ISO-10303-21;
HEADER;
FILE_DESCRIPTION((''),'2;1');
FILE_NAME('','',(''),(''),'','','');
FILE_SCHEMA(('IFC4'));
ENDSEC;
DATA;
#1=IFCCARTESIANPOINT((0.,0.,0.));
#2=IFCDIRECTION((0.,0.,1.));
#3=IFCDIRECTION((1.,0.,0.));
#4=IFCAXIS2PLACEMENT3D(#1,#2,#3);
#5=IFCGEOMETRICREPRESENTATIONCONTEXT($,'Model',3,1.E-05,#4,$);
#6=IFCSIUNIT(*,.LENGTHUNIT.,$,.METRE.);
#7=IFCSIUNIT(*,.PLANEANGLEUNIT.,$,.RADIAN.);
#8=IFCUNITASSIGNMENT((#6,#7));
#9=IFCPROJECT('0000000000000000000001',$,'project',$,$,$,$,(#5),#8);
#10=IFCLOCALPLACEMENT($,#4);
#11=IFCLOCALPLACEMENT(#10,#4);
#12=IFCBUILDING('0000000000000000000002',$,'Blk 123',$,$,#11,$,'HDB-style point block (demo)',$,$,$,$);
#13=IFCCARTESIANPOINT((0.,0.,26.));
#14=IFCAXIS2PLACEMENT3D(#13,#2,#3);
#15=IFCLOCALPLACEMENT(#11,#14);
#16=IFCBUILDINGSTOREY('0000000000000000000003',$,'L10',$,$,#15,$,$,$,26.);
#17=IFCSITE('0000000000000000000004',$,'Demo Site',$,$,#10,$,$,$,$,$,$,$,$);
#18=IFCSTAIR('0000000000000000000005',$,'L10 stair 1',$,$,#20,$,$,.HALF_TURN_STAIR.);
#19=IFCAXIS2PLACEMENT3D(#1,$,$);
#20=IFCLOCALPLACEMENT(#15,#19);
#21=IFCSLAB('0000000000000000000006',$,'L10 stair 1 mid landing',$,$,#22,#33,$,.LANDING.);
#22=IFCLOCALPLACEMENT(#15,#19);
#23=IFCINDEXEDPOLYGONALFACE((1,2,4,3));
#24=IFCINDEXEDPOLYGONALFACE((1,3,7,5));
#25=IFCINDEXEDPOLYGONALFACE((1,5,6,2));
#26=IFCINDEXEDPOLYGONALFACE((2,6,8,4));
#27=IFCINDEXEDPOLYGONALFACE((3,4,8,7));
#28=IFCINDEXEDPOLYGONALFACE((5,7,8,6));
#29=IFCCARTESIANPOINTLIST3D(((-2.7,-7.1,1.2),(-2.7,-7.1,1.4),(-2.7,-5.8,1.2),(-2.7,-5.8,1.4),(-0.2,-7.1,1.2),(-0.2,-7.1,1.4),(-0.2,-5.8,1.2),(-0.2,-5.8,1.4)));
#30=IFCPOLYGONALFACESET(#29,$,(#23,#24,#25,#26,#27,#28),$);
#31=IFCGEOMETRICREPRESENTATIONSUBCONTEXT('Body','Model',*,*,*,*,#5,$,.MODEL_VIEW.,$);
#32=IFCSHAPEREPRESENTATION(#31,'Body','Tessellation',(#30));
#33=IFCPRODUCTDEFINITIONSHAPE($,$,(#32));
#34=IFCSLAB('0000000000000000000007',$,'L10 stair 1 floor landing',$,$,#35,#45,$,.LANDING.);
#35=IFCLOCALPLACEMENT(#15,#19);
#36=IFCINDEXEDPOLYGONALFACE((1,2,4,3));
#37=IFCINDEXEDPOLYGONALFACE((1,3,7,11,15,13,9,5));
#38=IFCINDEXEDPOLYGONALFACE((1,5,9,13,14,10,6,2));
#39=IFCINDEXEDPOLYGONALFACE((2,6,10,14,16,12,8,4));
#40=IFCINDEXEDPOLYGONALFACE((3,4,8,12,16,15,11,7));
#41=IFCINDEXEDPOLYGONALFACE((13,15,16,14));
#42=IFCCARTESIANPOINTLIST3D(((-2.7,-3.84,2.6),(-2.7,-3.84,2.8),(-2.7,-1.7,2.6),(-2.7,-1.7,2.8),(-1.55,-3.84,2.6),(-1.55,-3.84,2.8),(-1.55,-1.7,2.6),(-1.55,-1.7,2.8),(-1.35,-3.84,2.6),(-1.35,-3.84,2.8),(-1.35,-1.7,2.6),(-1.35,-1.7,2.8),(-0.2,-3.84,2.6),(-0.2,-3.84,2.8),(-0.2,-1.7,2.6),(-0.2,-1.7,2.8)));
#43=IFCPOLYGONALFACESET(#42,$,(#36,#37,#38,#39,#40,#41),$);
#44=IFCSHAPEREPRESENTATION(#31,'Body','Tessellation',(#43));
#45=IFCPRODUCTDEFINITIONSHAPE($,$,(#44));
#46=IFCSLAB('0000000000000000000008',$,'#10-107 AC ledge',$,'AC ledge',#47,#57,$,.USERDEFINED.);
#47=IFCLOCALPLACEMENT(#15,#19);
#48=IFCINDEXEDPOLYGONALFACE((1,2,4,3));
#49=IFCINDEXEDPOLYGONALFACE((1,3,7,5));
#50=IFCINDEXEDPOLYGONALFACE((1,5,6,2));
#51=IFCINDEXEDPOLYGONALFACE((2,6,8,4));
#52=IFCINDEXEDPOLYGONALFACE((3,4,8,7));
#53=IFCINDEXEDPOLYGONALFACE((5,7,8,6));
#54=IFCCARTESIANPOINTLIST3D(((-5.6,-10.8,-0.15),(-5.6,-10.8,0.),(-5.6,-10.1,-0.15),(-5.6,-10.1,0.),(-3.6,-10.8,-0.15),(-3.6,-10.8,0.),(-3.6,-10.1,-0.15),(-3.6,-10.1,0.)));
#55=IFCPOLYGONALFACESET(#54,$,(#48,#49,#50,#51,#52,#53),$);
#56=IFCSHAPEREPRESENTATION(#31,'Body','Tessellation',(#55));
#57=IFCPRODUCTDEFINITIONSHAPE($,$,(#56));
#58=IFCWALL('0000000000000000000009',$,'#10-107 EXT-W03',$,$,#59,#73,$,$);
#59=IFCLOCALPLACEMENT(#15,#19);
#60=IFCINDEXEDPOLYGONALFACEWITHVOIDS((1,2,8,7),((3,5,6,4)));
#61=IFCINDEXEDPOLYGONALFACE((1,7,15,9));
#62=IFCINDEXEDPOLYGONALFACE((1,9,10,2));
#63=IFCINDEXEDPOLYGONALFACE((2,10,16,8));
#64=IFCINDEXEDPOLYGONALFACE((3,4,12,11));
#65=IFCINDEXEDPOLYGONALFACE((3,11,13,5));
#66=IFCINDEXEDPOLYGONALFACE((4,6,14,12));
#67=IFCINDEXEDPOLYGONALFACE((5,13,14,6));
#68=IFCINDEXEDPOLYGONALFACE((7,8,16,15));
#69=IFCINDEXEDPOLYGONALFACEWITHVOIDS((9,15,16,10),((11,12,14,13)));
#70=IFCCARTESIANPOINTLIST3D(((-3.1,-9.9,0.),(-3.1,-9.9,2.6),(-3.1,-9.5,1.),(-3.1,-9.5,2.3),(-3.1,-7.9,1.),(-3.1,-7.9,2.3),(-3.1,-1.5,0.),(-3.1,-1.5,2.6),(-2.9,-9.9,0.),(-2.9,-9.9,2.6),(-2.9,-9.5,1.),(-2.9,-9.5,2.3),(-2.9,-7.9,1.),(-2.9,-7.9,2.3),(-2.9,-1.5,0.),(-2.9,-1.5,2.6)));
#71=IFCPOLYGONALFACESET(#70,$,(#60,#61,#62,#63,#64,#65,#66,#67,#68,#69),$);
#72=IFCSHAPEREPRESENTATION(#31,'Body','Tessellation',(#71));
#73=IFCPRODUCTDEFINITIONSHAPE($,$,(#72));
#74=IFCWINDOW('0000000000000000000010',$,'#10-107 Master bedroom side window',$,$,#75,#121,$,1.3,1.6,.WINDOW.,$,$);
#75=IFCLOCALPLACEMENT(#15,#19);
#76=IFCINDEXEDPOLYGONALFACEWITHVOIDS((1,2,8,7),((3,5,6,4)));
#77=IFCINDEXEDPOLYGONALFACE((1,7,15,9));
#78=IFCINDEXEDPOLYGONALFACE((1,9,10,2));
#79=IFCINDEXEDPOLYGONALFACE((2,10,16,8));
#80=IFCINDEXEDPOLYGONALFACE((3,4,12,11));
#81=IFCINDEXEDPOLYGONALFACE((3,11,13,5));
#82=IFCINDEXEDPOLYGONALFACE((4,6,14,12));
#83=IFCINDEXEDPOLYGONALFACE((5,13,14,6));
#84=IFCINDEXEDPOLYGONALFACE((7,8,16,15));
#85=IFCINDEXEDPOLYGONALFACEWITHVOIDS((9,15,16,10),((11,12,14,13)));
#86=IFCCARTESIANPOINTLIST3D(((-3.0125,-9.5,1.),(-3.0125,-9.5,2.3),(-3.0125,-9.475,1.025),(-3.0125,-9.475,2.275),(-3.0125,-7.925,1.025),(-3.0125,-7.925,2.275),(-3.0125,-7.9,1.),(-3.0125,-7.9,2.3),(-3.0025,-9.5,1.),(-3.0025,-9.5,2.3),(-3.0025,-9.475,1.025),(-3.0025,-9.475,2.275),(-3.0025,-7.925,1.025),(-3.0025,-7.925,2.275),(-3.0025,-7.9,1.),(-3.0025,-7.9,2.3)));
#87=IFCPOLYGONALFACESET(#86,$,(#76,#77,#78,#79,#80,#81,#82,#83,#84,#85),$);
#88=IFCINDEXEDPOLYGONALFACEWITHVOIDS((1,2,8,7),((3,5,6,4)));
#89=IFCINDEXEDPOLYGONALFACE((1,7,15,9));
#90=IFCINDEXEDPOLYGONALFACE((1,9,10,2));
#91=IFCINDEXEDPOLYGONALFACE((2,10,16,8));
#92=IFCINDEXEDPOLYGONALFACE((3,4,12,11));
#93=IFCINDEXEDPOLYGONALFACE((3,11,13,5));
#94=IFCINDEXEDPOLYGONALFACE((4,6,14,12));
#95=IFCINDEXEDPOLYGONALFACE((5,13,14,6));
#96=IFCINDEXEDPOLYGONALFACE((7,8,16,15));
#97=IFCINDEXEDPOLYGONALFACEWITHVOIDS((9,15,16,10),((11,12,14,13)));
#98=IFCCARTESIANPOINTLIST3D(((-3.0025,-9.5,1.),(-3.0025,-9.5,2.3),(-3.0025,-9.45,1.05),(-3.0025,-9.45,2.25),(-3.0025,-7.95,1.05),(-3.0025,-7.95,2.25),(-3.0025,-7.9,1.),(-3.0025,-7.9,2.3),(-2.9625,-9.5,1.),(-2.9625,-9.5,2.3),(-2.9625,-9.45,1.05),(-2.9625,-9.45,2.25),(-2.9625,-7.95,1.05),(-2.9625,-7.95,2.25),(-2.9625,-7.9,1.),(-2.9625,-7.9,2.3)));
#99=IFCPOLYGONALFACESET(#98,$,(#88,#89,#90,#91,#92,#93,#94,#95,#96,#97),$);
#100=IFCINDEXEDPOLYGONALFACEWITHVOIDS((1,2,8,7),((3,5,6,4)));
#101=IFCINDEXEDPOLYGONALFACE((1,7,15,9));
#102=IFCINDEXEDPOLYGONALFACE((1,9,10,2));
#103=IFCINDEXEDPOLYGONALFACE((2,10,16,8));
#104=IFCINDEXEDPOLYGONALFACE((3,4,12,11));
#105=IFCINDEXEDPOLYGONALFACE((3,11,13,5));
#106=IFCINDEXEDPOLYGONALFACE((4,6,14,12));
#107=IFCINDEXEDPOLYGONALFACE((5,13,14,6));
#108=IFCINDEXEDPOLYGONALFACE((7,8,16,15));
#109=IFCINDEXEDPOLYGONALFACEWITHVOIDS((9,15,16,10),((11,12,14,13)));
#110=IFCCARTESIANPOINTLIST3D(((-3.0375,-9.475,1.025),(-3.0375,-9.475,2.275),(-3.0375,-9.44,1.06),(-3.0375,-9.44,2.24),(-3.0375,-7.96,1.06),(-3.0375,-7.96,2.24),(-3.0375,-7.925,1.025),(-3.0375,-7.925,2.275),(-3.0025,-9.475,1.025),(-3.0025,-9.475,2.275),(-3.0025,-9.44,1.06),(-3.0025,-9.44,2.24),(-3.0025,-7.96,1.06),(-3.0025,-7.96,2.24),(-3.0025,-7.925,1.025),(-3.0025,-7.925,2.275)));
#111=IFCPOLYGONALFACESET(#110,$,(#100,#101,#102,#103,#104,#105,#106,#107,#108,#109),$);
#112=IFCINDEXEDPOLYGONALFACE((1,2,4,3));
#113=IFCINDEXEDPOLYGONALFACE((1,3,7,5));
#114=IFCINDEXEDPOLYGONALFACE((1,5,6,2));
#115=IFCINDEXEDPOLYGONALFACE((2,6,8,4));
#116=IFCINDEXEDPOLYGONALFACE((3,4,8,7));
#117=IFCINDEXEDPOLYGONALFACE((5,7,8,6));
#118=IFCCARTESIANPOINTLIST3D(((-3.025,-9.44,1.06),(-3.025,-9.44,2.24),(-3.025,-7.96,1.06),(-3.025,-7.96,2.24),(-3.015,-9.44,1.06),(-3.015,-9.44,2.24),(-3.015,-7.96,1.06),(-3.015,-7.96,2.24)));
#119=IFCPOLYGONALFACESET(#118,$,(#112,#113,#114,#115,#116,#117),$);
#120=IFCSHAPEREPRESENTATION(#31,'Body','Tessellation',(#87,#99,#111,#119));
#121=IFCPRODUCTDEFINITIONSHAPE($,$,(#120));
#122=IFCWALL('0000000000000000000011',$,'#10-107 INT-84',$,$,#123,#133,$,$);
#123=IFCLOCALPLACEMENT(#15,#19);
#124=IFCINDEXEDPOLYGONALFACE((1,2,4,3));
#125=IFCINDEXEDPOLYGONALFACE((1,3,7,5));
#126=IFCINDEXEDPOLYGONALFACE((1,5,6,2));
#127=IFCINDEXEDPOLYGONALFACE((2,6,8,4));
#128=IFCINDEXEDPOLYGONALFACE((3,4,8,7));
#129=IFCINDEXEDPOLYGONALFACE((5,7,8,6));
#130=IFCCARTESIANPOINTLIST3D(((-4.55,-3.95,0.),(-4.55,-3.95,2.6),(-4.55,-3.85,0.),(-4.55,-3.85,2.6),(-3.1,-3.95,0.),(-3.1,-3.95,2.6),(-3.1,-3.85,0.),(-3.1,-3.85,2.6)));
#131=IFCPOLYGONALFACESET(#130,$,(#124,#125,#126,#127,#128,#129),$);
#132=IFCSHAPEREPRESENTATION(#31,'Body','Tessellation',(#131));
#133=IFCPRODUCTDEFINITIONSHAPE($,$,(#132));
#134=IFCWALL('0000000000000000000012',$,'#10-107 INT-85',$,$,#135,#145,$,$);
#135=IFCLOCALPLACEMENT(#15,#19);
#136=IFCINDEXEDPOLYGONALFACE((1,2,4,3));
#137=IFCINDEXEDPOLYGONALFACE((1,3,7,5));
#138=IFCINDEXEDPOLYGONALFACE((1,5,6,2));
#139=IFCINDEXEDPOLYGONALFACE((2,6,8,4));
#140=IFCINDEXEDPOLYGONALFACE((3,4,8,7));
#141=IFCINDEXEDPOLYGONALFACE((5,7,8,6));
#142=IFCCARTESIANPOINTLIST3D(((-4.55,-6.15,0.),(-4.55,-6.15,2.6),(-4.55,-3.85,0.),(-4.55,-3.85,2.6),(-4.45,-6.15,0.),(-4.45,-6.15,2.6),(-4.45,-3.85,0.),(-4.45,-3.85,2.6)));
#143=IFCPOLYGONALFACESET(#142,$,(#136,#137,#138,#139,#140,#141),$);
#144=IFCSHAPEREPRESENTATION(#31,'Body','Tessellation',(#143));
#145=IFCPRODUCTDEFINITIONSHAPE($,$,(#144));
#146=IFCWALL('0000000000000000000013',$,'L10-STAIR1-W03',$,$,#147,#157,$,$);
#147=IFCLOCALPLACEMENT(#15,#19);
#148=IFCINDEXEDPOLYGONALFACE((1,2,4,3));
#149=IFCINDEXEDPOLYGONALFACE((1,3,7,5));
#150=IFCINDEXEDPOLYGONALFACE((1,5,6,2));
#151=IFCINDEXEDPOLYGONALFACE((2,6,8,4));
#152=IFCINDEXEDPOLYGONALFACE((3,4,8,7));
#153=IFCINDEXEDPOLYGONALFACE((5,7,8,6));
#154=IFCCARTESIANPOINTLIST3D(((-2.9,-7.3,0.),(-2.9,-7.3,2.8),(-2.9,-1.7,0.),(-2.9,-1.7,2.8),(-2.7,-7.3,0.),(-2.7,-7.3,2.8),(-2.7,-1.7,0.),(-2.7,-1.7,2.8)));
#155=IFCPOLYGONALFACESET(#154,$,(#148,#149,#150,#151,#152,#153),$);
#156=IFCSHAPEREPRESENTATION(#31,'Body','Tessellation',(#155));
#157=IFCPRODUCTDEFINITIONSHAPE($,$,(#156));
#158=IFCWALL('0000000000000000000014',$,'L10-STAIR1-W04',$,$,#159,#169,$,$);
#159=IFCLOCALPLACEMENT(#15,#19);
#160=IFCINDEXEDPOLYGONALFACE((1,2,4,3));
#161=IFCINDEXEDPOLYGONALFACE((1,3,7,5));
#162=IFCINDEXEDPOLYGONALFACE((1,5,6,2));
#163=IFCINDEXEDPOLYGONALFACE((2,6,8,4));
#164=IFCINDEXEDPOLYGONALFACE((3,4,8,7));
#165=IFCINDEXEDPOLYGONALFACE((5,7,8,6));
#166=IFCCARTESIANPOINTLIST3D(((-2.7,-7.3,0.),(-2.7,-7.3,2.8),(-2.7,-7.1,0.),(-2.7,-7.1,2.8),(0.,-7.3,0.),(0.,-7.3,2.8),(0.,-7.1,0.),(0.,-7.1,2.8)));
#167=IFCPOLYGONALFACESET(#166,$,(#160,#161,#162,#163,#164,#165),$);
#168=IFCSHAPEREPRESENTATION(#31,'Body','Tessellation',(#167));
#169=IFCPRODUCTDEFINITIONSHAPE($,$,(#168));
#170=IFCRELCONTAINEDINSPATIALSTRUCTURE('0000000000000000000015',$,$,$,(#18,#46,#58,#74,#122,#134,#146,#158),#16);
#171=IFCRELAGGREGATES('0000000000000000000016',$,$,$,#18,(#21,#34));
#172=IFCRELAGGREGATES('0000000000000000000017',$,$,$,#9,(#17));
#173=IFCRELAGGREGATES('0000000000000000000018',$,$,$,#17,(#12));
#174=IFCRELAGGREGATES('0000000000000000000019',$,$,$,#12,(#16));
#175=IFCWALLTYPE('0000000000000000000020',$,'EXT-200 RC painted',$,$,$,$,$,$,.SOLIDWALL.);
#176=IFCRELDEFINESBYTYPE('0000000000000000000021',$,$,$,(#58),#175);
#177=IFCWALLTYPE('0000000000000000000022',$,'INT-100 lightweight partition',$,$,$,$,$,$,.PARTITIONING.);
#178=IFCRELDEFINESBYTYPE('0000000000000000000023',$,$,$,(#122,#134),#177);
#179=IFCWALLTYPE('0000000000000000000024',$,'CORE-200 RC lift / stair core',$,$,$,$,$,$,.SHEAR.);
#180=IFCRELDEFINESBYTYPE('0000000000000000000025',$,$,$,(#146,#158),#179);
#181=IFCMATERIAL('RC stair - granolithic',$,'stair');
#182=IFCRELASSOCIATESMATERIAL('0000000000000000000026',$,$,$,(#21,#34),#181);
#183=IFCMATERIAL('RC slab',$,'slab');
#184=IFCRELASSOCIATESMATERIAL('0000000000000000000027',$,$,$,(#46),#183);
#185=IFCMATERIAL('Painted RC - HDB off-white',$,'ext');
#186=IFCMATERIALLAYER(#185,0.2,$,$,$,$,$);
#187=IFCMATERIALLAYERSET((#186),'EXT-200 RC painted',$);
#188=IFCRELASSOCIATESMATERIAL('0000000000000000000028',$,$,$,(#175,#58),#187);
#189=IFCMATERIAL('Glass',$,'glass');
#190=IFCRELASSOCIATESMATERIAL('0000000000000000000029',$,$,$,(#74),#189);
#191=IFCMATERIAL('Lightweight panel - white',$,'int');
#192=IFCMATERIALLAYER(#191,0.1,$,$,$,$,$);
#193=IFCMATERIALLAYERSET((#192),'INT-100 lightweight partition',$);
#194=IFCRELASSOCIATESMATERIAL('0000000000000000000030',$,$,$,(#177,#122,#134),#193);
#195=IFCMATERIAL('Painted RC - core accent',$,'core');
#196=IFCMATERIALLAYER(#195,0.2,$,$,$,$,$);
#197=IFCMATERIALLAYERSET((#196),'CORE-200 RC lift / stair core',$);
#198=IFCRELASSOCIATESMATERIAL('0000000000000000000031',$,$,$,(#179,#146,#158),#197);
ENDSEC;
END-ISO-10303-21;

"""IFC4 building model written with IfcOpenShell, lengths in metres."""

from ifc_helpers import new_model, si_unit, frame, origin, origin_with_axes, place, context, subcontext, project, spatial, polyline, line, indexed_curve, outline, extrude, material, layer, layer_set, layer_usage, type_object, element, fill, aggregate, save


model = new_model("IFC4")

# Units and contexts
model_context = context("Model", 3, precision=1e-05, world=origin_with_axes())
body_context = subcontext(model_context, "Body", "Model", "MODEL_VIEW")
ifc_project = project(units=[si_unit("LENGTHUNIT", "METRE"), si_unit("PLANEANGLEUNIT", "RADIAN")], contexts=[model_context])

# Site, building, storey
site_placement = place(None, origin_with_axes())
site = spatial("IfcSite", under=ifc_project, at=site_placement, Name="Demo Site")
building_placement = place(site_placement, origin_with_axes())
building = spatial("IfcBuilding", under=site, at=building_placement, Name="Blk 123", LongName="HDB-style point block (demo)")
storey_placement = place(building_placement, frame((0.0, 0.0, 26.0), z_axis=(0.0, 0.0, 1.0), x_axis=(1.0, 0.0, 0.0)))
storey = spatial("IfcBuildingStorey", under=building, at=storey_placement, Name="L10", Elevation=26.0)

# Stair, slabs
stair_placement = place(storey_placement, frame((-2.7, -7.1, 0.0), z_axis=(0.0, 0.0, 1.0), x_axis=(1.0, 0.0, 0.0)))
stair = element("IfcStair", 1, at=stair_placement, inside=storey, Name="L10 stair 1", PredefinedType="HALF_TURN_STAIR")
ifc_material_1 = material(Name="RC stair - granolithic", Category="stair")
slab_1_placement = place(stair_placement, frame((1.25, 0.65, 1.2), z_axis=(0.0, 0.0, 1.0), x_axis=(1.0, 0.0, 0.0)))
slab_1 = element("IfcSlab", 2, at=slab_1_placement, material=ifc_material_1, Name="L10 stair 1 mid landing", PredefinedType="LANDING", context=body_context, shape_type="SweptSolid", body=[
    extrude(outline(polyline([(1.25, -0.65), (1.25, 0.65), (-1.25, 0.65), (-1.25, -0.65), (1.25, -0.65)])), origin(), (0.0, 0.0, 1.0), 0.2),
])
slab_2_placement = place(stair_placement, frame((1.25, 4.33, 2.6), z_axis=(0.0, 0.0, 1.0), x_axis=(1.0, 0.0, 0.0)))
slab_2 = element("IfcSlab", 3, at=slab_2_placement, material=ifc_material_1, Name="L10 stair 1 floor landing", PredefinedType="LANDING", context=body_context, shape_type="SweptSolid", body=[
    extrude(outline(polyline([(-0.1, 1.07), (-1.25, 1.07), (-1.25, -1.07), (-0.1, -1.07), (0.1, -1.07), (1.25, -1.07), (1.25, 1.07), (0.1, 1.07), (-0.1, 1.07)])), origin(), (0.0, 0.0, 1.0), 0.2),
])

# Slab
ifc_material_2 = material(Name="RC slab", Category="slab")
slab_3_placement = place(storey_placement, frame((-4.6, -10.45, -0.15), z_axis=(0.0, 0.0, 1.0), x_axis=(1.0, 0.0, 0.0)))
element("IfcSlab", 4, at=slab_3_placement, inside=storey, material=ifc_material_2, Name="#10-107 AC ledge", ObjectType="AC ledge", PredefinedType="USERDEFINED", context=body_context, shape_type="SweptSolid", body=[
    extrude(outline(polyline([(-1.0, 0.35), (-1.0, -0.35), (1.0, -0.35), (1.0, 0.35), (-1.0, 0.35)])), origin(), (0.0, 0.0, 1.0), 0.15),
])

# Wall, opening, window
ifc_material_3 = material(Name="Painted RC - HDB off-white", Category="ext")
ifc_layer_1 = layer(ifc_material_3, 0.2)
ifc_layer_set_1 = layer_set([ifc_layer_1], Name="EXT-200 RC painted")
ifc_layer_usage_1 = layer_usage(ifc_layer_set_1, "AXIS2", "POSITIVE", 0.0)
wall_type_1 = type_object("IfcWallType", Name="EXT-200 RC painted", PredefinedType="SOLIDWALL", material=ifc_layer_set_1)
wall_1_placement = place(storey_placement, frame((-2.9, -9.9, 0.0), z_axis=(0.0, 0.0, 1.0), x_axis=(0.0, 1.0, 0.0)))
wall_1 = element("IfcWall", 5, at=wall_1_placement, inside=storey, type_object=wall_type_1, material=ifc_layer_usage_1, Name="#10-107 EXT-W03", context=body_context, shape_type="SweptSolid", body=[
    extrude(outline(indexed_curve([(0.0, 0.0), (0.0, 0.2), (8.4, 0.2), (8.4, 0.0), (0.0, 0.0)], self_intersect=False)), origin_with_axes(), (0.0, 0.0, 1.0), 2.6),
])
opening_1_placement = place(wall_1_placement, frame((0.4, -0.1, 1.0), z_axis=(0.0, 0.0, 1.0), x_axis=(1.0, 0.0, 0.0)))
opening_1 = element("IfcOpeningElement", 6, at=opening_1_placement, cuts=wall_1, context=body_context, shape_type="SweptSolid", body=[
    extrude(outline(indexed_curve([(0.0, 0.0), (0.0, 0.4), (1.6, 0.4), (1.6, 0.0), (0.0, 0.0)], self_intersect=False)), origin_with_axes(), (0.0, 0.0, 1.0), 1.3),
])
ifc_material_4 = material(Name="Glass", Category="glass")
window_placement = place(opening_1_placement, frame((0.0, 0.1125, 0.0), z_axis=(0.0, 0.0, 1.0), x_axis=(1.0, 0.0, 0.0)))
window = element("IfcWindow", 7, at=window_placement, inside=storey, material=ifc_material_4, Name="#10-107 Master bedroom side window", OverallHeight=1.3, OverallWidth=1.6, PredefinedType="WINDOW", context=body_context, shape_type="SweptSolid", body=[
    extrude(outline(indexed_curve([(0.0, 0.0), (1.6, 0.0), (1.6, 1.3), (0.0, 1.3)], segments=[line(1, 2, 3, 4, 1)]), holes=[indexed_curve([(0.025, 0.025), (1.575, 0.025), (1.575, 1.275), (0.025, 1.275)], segments=[line(1, 2, 3, 4, 1)])]), frame((0.0, 0.09, 0.0), z_axis=(0.0, -1.0, 0.0), x_axis=(1.0, 0.0, 0.0)), (0.0, 0.0, -1.0), 0.01),
    extrude(outline(indexed_curve([(0.0, 0.0), (1.6, 0.0), (1.6, 1.3), (0.0, 1.3)], segments=[line(1, 2, 3, 4, 1)]), holes=[indexed_curve([(0.05, 0.05), (1.55, 0.05), (1.55, 1.25), (0.05, 1.25)], segments=[line(1, 2, 3, 4, 1)])]), frame((0.0, 0.05, 0.0), z_axis=(0.0, -1.0, 0.0), x_axis=(1.0, 0.0, 0.0)), (0.0, 0.0, -1.0), 0.04),
    extrude(outline(indexed_curve([(0.0, 0.0), (1.55, 0.0), (1.55, 1.25), (0.0, 1.25)], segments=[line(1, 2, 3, 4, 1)]), holes=[indexed_curve([(0.035, 0.035), (1.515, 0.035), (1.515, 1.215), (0.035, 1.215)], segments=[line(1, 2, 3, 4, 1)])]), frame((0.025, 0.09, 0.025), z_axis=(0.0, -1.0, 0.0), x_axis=(1.0, 0.0, 0.0)), (0.0, 0.0, -1.0), 0.035),
    extrude(outline(indexed_curve([(0.035, 0.035), (1.515, 0.035), (1.515, 1.215), (0.035, 1.215)], segments=[line(1, 2, 3, 4, 1)])), frame((0.025, 0.1025, 0.025), z_axis=(0.0, -1.0, 0.0), x_axis=(1.0, 0.0, 0.0)), (0.0, 0.0, -1.0), 0.01),
])
fill(opening_1, window)

# Shared definitions
ifc_material_5 = material(Name="Lightweight panel - white", Category="int")
ifc_layer_2 = layer(ifc_material_5, 0.1)
ifc_layer_set_2 = layer_set([ifc_layer_2], Name="INT-100 lightweight partition")
ifc_layer_usage_2 = layer_usage(ifc_layer_set_2, "AXIS2", "POSITIVE", -0.05)
wall_type_2 = type_object("IfcWallType", Name="INT-100 lightweight partition", PredefinedType="PARTITIONING", material=ifc_layer_set_2)

# Walls
wall_2_placement = place(storey_placement, frame((-3.1, -3.9, 0.0), z_axis=(0.0, 0.0, 1.0), x_axis=(-1.0, 0.0, 0.0)))
element("IfcWall", 8, at=wall_2_placement, inside=storey, type_object=wall_type_2, material=ifc_layer_usage_2, Name="#10-107 INT-84", context=body_context, shape_type="SweptSolid", body=[
    extrude(outline(indexed_curve([(0.0, 0.0), (0.0, 0.1), (1.45, 0.1), (1.45, 0.0), (0.0, 0.0)], self_intersect=False)), frame((0.0, -0.05, 0.0), z_axis=(0.0, 0.0, 1.0), x_axis=(1.0, 0.0, 0.0)), (0.0, 0.0, 1.0), 2.6),
])
wall_3_placement = place(storey_placement, frame((-4.5, -3.85, 0.0), z_axis=(0.0, 0.0, 1.0), x_axis=(0.0, -1.0, 0.0)))
element("IfcWall", 9, at=wall_3_placement, inside=storey, type_object=wall_type_2, material=ifc_layer_usage_2, Name="#10-107 INT-85", context=body_context, shape_type="SweptSolid", body=[
    extrude(outline(indexed_curve([(0.0, 0.0), (0.0, 0.1), (2.3, 0.1), (2.3, 0.0), (0.0, 0.0)], self_intersect=False)), frame((0.0, -0.05, 0.0), z_axis=(0.0, 0.0, 1.0), x_axis=(1.0, 0.0, 0.0)), (0.0, 0.0, 1.0), 2.6),
])

# Walls
ifc_material_6 = material(Name="Painted RC - core accent", Category="core")
ifc_layer_3 = layer(ifc_material_6, 0.2)
ifc_layer_set_3 = layer_set([ifc_layer_3], Name="CORE-200 RC lift / stair core")
ifc_layer_usage_3 = layer_usage(ifc_layer_set_3, "AXIS2", "POSITIVE", 0.0)
wall_type_3 = type_object("IfcWallType", Name="CORE-200 RC lift / stair core", PredefinedType="SHEAR", material=ifc_layer_set_3)
wall_4_placement = place(storey_placement, frame((-2.9, -1.7, 0.0), z_axis=(0.0, 0.0, 1.0), x_axis=(0.0, -1.0, 0.0)))
element("IfcWall", 10, at=wall_4_placement, inside=storey, type_object=wall_type_3, material=ifc_layer_usage_3, Name="L10-STAIR1-W03", context=body_context, shape_type="SweptSolid", body=[
    extrude(outline(indexed_curve([(0.0, 0.0), (0.0, 0.2), (5.6, 0.2), (5.6, 0.0), (0.0, 0.0)], self_intersect=False)), origin_with_axes(), (0.0, 0.0, 1.0), 2.8),
])
wall_5_placement = place(storey_placement, frame((-2.7, -7.3, 0.0), z_axis=(0.0, 0.0, 1.0), x_axis=(1.0, 0.0, 0.0)))
element("IfcWall", 11, at=wall_5_placement, inside=storey, type_object=wall_type_3, material=ifc_layer_usage_3, Name="L10-STAIR1-W04", context=body_context, shape_type="SweptSolid", body=[
    extrude(outline(indexed_curve([(0.0, 0.0), (0.0, 0.2), (2.7, 0.2), (2.7, 0.0), (0.0, 0.0)], self_intersect=False)), origin_with_axes(), (0.0, 0.0, 1.0), 2.8),
])

aggregate(stair, [slab_1, slab_2])

save(model, "model.ifc")
